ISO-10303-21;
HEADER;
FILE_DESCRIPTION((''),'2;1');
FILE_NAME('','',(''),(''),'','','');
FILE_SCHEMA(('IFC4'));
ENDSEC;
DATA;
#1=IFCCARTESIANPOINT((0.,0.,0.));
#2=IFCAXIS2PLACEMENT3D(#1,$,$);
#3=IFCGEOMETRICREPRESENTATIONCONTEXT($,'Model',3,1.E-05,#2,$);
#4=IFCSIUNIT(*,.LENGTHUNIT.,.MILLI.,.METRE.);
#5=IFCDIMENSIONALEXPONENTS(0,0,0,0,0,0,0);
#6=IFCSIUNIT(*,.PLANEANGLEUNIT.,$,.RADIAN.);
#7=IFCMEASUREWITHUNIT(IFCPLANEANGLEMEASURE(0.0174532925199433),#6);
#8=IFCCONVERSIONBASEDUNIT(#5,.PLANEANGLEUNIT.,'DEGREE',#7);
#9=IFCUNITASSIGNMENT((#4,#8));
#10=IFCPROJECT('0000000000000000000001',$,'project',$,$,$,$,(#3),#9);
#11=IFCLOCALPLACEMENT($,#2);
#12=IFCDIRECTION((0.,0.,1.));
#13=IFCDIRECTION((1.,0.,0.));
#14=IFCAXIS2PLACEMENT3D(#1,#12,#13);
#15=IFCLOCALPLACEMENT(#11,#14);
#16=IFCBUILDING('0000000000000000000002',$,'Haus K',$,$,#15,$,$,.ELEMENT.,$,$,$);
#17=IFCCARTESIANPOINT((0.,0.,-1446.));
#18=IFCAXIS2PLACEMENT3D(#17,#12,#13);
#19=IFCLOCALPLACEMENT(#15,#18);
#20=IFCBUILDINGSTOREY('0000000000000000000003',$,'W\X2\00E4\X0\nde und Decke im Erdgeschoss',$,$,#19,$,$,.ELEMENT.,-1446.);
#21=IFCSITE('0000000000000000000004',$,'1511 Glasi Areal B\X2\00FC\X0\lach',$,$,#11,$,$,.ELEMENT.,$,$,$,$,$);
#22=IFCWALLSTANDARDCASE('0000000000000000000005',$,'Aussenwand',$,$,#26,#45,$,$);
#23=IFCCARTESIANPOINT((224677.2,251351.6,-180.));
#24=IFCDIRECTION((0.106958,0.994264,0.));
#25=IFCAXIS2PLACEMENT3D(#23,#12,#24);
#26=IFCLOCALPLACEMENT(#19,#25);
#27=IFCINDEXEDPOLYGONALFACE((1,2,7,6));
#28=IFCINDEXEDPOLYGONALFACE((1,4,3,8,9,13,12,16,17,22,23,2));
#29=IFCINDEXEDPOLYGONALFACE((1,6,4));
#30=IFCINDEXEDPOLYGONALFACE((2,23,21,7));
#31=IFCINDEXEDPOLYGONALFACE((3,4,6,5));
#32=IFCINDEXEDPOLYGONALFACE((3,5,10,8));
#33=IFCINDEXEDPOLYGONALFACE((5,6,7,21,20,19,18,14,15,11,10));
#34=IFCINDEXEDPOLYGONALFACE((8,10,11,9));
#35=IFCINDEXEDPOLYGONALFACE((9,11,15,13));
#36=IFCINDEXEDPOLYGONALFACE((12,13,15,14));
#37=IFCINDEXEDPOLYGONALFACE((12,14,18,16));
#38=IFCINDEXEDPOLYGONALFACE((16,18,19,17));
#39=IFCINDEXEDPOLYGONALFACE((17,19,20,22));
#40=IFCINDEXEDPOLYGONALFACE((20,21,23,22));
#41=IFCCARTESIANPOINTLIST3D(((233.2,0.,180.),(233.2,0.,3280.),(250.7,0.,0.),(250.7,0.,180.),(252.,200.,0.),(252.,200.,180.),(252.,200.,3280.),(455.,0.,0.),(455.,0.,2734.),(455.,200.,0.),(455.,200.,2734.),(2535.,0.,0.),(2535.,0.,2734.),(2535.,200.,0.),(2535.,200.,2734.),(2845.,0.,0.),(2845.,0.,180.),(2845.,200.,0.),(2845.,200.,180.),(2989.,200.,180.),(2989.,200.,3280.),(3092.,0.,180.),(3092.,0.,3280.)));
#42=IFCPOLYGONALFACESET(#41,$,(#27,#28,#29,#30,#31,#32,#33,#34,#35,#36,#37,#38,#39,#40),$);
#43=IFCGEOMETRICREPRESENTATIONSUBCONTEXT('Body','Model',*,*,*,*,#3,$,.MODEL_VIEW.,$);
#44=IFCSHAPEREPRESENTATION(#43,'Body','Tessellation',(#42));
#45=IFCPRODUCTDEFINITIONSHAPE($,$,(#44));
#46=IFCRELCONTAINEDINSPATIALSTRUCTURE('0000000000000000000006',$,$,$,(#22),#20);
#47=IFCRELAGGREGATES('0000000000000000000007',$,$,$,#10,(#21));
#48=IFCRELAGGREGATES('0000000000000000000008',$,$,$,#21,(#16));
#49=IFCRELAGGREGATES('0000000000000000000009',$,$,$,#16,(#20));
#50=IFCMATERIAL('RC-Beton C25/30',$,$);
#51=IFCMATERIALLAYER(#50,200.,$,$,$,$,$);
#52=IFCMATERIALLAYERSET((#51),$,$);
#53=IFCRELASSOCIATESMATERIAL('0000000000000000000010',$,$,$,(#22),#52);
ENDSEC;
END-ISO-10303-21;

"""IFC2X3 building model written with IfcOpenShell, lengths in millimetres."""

from ifc_helpers import new_model, entity, si_unit, converted_unit, frame, frame_2d, origin, origin_with_axes, place, context, subcontext, project, spatial, polyline, rectangle, outline, extrude, clip, bounded_halfspace, material, layer, layer_set, layer_usage, element, save


model = new_model("IFC2X3")

# Units and contexts
model_context = context("Model", 3, precision=1e-05, world=origin())
body_context = subcontext(model_context, "Body", "Model", "MODEL_VIEW")
ifc_project = project(units=[si_unit("LENGTHUNIT", "METRE", prefix="MILLI"), converted_unit("PLANEANGLEUNIT", "DEGREE", entity("IfcPlaneAngleMeasure", 0.0174532925199433), si_unit("PLANEANGLEUNIT", "RADIAN"), dimensions=[0, 0, 0, 0, 0, 0, 0])], contexts=[model_context])

# Site, building, storey
site_placement = place(None, origin())
site = spatial("IfcSite", under=ifc_project, at=site_placement, Name="1511 Glasi Areal Bülach", CompositionType="ELEMENT")
building_placement = place(site_placement, origin_with_axes())
building = spatial("IfcBuilding", under=site, at=building_placement, Name="Haus K", CompositionType="ELEMENT")
storey_placement = place(building_placement, frame((0.0, 0.0, -1446.0), z_axis=(0.0, 0.0, 1.0), x_axis=(1.0, 0.0, 0.0)))
storey = spatial("IfcBuildingStorey", under=building, at=storey_placement, Name="Wände und Decke im Erdgeschoss", CompositionType="ELEMENT", Elevation=-1446.0)

# Wall, opening
ifc_material_1 = material(Name="RC-Beton C25/30")
ifc_layer_1 = layer(ifc_material_1, 200.0)
ifc_layer_set_1 = layer_set([ifc_layer_1])
ifc_layer_usage_1 = layer_usage(ifc_layer_set_1, "AXIS2", "POSITIVE", 0.0)
wall_1_placement = place(storey_placement, frame((224677.2, 251351.6, -180.0), z_axis=(0.0, 0.0, 1.0), x_axis=(0.106958, 0.994264, 0.0)))
wall_1 = element("IfcWallStandardCase", 1, at=wall_1_placement, inside=storey, material=ifc_layer_usage_1, Name="Aussenwand", context=body_context, shape_type="Clipping", body=[
    clip(clip(clip(clip(clip(extrude(outline(polyline([(233.2, 0.0), (3092.0, 0.0), (2989.0, 200.0), (252.0, 200.0), (233.2, 0.0)])), origin_with_axes(), (0.0, 0.0, 1.0), 3280.0), bounded_halfspace(frame((2845.0, 0.0, 0.0), z_axis=(0.0, 0.0, 1.0), x_axis=(0.0, 1.0, 0.0)), True, origin(), polyline([(2845.0, 0.0), (2845.0, 200.0), (252.0, 200.0), (250.7, 0.0), (2845.0, 0.0)]))), bounded_halfspace(frame((2845.0, 0.0, 180.0), z_axis=(0.0, 0.0, 1.0), x_axis=(1.0, 0.0, 0.0)), True, origin(), polyline([(2845.0, 0.0), (3092.0, 0.0), (2989.0, 200.0), (2845.0, 200.0), (2845.0, 0.0)]))), bounded_halfspace(frame((0.0, 0.0, 180.0), z_axis=(0.0, 0.0, 1.0), x_axis=(1.0, 0.0, 0.0)), True, origin(), polyline([(0.0, 0.0), (233.2, 0.0), (0.0, 44.1), (0.0, 0.0)]))), bounded_halfspace(frame((252.0, 200.0, 180.0), z_axis=(0.0, 0.0, 1.0), x_axis=(-0.093326, -0.995636, 0.0)), True, origin(), polyline([(252.0, 200.0), (233.2, 0.0), (250.7, 0.0), (252.0, 200.0)]))), bounded_halfspace(frame((3095.0, 4.2, 180.0), z_axis=(0.0, 0.0, 1.0), x_axis=(-0.580703, -0.814116, 0.0)), True, origin(), polyline([(3095.0, 4.2), (3092.0, 0.0), (3095.0, 0.0), (3095.0, 4.2)]))),
])
opening_1_placement = place(wall_1_placement, frame((455.0, 0.0, 0.0), z_axis=(0.0, 1.0, 0.0), x_axis=(0.0, 0.0, 1.0)))
element("IfcOpeningElement", 2, at=opening_1_placement, cuts=wall_1, ObjectType="Opening", context=body_context, shape_type="SweptSolid", body=[
    extrude(rectangle(XDim=2734.0, YDim=2080.0, at=frame_2d((1367.0, 1040.0), x_axis=(1.0, 0.0))), origin_with_axes(), (0.0, 0.0, 1.0), 200.0),
])

save(model, "model.ifc")
